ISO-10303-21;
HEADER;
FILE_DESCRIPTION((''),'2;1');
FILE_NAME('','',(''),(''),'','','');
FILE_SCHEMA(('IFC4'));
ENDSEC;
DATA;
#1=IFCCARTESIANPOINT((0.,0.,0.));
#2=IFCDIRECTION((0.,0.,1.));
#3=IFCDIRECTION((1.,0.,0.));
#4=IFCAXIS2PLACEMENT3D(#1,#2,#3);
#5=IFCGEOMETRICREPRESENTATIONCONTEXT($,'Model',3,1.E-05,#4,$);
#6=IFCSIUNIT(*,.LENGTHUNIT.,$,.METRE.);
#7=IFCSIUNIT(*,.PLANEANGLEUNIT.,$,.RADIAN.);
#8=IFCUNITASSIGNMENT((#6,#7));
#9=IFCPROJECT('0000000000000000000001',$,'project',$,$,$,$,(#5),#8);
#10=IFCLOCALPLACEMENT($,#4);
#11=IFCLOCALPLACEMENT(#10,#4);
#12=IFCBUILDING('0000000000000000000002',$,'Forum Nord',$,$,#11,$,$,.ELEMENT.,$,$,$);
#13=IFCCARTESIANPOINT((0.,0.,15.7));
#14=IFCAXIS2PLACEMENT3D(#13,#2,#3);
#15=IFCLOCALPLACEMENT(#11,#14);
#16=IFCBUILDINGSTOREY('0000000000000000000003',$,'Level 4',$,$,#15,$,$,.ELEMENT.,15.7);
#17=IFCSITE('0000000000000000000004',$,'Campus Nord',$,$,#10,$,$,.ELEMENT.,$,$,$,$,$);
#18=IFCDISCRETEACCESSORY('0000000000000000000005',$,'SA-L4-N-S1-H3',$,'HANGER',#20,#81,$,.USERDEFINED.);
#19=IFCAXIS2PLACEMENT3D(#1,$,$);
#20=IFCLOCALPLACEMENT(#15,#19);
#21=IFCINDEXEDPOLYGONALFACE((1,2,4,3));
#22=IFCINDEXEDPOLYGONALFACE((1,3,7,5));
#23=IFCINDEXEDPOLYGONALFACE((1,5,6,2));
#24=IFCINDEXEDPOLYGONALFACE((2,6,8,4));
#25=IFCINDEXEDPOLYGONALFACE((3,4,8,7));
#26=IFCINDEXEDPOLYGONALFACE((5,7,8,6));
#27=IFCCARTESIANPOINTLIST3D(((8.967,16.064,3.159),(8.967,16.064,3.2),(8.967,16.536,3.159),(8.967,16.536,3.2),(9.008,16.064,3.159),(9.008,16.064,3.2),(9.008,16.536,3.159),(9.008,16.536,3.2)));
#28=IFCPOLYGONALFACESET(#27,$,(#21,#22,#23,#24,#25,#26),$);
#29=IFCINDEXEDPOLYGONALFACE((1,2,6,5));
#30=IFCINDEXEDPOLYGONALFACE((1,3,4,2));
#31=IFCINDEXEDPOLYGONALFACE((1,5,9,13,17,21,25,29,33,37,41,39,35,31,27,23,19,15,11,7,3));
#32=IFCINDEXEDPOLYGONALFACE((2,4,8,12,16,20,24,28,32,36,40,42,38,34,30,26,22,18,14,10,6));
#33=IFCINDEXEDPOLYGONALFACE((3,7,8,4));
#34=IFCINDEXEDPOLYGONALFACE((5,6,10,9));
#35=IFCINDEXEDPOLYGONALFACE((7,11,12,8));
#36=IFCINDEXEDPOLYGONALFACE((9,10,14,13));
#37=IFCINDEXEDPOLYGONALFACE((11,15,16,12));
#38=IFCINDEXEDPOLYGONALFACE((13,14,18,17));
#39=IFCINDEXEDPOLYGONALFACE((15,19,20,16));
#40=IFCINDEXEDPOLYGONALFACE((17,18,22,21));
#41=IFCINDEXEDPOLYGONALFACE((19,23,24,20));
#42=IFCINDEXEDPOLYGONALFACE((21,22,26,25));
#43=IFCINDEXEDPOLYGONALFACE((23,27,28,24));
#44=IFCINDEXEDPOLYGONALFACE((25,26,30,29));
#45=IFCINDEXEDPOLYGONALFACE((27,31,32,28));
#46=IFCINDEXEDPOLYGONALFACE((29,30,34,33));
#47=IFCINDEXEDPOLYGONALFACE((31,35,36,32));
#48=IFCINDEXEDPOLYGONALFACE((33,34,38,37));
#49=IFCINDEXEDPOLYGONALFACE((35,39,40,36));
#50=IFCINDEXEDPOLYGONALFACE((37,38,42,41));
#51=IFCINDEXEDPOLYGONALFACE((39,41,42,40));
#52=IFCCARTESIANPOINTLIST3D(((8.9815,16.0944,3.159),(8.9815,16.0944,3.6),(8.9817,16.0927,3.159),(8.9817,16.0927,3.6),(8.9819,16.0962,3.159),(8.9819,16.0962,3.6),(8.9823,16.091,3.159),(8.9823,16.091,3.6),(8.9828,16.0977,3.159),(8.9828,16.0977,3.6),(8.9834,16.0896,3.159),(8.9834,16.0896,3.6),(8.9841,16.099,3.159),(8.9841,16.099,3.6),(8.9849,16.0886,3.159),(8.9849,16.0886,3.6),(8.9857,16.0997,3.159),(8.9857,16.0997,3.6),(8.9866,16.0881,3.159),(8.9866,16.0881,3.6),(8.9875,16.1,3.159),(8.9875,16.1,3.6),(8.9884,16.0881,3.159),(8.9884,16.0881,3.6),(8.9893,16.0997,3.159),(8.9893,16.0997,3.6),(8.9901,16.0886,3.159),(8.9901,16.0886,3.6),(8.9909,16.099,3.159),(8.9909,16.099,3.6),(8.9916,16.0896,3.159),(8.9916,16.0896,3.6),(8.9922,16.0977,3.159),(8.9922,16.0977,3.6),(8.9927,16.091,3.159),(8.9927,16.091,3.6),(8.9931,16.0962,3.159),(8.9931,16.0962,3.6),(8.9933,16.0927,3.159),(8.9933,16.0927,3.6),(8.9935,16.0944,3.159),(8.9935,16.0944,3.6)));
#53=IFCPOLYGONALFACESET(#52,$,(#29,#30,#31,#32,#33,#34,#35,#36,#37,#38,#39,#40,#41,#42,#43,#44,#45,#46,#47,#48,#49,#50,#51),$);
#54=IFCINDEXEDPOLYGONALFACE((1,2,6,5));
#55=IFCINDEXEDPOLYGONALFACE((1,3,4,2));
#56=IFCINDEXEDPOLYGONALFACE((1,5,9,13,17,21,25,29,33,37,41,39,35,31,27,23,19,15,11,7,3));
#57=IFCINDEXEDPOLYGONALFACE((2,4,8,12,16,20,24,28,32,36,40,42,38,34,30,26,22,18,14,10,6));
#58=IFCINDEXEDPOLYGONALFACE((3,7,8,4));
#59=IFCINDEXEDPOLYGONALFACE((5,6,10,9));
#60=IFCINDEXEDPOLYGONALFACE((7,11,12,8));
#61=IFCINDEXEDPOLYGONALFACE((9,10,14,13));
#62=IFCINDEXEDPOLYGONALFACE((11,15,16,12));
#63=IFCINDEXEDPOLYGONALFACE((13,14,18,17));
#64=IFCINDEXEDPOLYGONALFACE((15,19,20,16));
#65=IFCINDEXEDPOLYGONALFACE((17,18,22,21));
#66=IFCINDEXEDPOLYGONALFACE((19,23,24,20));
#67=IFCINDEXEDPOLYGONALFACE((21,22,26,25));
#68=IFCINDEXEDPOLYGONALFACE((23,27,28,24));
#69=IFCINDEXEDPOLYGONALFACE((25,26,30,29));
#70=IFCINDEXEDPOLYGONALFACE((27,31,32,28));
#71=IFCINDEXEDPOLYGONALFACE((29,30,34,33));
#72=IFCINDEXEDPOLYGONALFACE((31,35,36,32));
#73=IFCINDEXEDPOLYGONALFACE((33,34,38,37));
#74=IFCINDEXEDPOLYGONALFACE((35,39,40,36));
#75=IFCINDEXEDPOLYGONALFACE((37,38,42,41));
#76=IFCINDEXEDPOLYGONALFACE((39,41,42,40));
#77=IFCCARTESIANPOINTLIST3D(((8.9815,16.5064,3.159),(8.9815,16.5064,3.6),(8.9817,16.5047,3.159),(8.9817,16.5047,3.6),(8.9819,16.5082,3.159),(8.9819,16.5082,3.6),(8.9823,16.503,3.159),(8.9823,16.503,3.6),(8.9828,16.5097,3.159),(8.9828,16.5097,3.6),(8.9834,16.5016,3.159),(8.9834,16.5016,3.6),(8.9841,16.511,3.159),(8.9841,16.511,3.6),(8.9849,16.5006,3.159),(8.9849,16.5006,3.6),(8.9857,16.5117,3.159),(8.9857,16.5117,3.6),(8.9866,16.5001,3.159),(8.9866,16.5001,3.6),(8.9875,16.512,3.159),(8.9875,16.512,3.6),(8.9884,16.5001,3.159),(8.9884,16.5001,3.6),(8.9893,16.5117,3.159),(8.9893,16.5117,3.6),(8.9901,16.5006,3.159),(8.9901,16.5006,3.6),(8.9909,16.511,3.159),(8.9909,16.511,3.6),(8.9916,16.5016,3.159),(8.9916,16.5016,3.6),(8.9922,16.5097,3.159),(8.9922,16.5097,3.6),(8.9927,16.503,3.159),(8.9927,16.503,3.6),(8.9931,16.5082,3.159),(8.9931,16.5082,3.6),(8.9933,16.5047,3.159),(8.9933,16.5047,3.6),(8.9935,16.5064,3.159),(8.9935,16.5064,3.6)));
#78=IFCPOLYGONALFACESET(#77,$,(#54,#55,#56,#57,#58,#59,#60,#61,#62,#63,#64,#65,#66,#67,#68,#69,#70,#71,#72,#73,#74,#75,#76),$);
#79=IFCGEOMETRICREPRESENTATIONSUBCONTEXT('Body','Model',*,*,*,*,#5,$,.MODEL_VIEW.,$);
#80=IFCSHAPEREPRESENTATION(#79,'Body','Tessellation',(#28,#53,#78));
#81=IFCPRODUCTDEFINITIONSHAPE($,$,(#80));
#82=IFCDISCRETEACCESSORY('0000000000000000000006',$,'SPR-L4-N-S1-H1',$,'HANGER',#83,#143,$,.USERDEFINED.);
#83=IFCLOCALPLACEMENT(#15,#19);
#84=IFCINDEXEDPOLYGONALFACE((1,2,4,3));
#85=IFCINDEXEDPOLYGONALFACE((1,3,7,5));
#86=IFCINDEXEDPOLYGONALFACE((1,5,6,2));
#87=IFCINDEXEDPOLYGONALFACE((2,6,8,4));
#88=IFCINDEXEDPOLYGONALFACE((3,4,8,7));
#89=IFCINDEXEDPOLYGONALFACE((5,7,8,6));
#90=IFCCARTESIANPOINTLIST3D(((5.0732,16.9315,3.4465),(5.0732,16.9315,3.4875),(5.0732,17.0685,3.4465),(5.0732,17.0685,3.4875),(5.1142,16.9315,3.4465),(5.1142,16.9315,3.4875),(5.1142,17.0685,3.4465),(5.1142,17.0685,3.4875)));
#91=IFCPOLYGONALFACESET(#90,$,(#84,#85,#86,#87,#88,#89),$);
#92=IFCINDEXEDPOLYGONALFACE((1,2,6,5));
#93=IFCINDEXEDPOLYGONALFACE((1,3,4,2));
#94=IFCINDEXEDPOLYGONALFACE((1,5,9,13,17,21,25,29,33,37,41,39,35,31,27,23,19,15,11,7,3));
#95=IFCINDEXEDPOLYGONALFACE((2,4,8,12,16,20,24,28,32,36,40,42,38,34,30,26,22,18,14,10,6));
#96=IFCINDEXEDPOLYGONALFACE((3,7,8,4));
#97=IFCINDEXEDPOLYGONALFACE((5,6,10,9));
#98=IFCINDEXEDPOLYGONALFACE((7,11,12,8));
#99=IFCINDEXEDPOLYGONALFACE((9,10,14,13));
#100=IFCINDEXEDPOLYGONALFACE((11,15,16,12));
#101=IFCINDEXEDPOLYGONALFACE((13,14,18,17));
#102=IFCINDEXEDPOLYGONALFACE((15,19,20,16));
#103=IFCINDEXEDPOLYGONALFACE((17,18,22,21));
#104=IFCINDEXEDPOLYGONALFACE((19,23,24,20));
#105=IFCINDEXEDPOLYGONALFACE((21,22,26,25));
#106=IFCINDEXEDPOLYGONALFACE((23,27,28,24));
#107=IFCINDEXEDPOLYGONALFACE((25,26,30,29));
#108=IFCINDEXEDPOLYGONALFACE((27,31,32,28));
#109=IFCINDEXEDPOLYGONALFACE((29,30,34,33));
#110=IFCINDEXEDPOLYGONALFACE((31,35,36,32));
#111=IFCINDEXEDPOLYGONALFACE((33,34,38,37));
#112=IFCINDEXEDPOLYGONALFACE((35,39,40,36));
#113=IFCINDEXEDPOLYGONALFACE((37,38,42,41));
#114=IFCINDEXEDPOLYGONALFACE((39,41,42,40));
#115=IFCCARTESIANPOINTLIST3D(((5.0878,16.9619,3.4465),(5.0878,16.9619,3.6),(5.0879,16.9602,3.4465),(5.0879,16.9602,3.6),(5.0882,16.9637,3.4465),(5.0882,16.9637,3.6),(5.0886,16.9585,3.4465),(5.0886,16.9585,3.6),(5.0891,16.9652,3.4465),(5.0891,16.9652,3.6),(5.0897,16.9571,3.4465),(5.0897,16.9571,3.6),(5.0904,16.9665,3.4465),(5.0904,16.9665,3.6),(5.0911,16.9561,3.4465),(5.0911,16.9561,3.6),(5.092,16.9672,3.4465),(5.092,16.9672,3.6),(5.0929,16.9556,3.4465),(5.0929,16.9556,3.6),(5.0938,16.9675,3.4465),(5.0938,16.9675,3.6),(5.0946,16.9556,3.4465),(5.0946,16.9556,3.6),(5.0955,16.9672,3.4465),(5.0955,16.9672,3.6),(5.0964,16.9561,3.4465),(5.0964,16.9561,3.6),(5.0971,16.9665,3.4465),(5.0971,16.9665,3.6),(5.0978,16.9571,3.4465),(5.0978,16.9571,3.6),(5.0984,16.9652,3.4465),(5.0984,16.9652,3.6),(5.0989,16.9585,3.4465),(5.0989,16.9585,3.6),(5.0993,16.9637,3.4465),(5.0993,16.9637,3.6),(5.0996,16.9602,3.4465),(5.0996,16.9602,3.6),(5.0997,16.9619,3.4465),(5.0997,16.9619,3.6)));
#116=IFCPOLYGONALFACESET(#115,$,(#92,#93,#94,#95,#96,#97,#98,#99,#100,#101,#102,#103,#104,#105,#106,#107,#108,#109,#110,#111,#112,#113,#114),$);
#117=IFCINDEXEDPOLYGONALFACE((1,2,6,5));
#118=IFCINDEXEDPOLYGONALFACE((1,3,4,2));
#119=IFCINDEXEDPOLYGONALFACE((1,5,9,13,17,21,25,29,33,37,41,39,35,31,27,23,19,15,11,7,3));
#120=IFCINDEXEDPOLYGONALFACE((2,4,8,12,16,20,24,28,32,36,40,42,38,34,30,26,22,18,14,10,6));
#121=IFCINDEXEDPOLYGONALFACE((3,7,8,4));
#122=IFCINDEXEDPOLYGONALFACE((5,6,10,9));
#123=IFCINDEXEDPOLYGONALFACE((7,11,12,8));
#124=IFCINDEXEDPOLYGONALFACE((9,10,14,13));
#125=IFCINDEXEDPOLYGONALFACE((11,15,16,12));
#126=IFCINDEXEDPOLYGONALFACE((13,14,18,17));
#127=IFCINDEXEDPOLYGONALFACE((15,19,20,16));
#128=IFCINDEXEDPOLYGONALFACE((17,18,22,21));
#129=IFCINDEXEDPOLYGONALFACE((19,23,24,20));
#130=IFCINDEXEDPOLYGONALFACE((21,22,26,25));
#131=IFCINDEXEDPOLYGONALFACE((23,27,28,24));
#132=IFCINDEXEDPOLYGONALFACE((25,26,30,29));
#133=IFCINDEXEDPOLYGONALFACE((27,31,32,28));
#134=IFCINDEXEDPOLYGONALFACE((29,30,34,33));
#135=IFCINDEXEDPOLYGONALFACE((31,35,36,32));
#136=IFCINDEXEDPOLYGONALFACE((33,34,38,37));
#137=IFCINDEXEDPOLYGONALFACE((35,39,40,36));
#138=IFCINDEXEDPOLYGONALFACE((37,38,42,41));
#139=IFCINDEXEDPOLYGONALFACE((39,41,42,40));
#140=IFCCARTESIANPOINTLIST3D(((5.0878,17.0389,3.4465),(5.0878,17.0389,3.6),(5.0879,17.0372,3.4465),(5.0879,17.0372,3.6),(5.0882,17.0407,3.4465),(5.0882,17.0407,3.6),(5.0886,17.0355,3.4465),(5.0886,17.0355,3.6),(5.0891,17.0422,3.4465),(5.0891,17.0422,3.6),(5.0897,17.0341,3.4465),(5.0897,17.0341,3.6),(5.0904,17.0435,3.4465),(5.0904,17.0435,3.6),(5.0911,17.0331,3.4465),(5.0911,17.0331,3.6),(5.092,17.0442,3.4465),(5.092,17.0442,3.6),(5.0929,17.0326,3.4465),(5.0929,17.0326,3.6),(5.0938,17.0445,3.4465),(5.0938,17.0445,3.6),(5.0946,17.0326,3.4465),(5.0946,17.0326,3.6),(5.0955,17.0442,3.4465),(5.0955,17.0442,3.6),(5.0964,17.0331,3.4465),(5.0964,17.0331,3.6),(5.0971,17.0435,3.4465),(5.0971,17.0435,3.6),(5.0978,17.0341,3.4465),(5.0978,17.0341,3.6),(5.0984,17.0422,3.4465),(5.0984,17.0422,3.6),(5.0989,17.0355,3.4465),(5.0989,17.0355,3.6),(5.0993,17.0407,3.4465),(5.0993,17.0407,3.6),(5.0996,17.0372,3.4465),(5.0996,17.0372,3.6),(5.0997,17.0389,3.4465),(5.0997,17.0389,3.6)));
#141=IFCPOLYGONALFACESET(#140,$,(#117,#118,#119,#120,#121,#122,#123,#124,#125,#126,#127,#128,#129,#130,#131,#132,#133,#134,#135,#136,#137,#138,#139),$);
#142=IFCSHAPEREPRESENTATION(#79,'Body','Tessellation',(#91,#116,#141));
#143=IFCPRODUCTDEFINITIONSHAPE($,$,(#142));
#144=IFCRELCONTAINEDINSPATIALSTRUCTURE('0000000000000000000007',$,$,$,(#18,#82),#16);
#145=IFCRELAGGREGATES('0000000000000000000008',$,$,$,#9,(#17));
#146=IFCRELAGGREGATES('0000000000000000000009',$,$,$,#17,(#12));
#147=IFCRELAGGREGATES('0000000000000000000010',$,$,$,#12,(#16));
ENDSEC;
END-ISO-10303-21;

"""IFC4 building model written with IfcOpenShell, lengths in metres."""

from ifc_helpers import new_model, si_unit, frame, frame_2d, origin_with_axes, origin_2d_with_axis, place, context, subcontext, project, spatial, rectangle, circle, extrude, element, save


model = new_model("IFC4")

# Units and contexts
model_context = context("Model", 3, precision=1e-05, world=origin_with_axes())
body_context = subcontext(model_context, "Body", "Model", "MODEL_VIEW")
ifc_project = project(units=[si_unit("LENGTHUNIT", "METRE"), si_unit("PLANEANGLEUNIT", "RADIAN")], contexts=[model_context])

# Site, building, storey
site_placement = place(None, origin_with_axes())
site = spatial("IfcSite", under=ifc_project, at=site_placement, Name="Campus Nord", CompositionType="ELEMENT")
building_placement = place(site_placement, origin_with_axes())
building = spatial("IfcBuilding", under=site, at=building_placement, Name="Forum Nord", CompositionType="ELEMENT")
storey_placement = place(building_placement, frame((0.0, 0.0, 15.7), z_axis=(0.0, 0.0, 1.0), x_axis=(1.0, 0.0, 0.0)))
storey = spatial("IfcBuildingStorey", under=building, at=storey_placement, Name="Level 4", CompositionType="ELEMENT", Elevation=15.7)

# Discrete accessories
for number, where, z_axis, x_axis, name in (
    (1, (8.9875, 16.3, 3.2), (0.0, 0.0, 1.0), (0.0, 1.0, 0.0), "SA-L4-N-S1-H3"),
):
    element("IfcDiscreteAccessory", number, at=place(storey_placement, frame(where, z_axis=z_axis, x_axis=x_axis)), inside=storey, Name=name, ObjectType="HANGER", PredefinedType="USERDEFINED", context=body_context, shape_type="SweptSolid", body=[
        extrude(rectangle(XDim=0.472, YDim=0.041, at=origin_2d_with_axis()), frame((0.0, 0.0, -0.041), z_axis=(0.0, 0.0, 1.0), x_axis=(1.0, 0.0, 0.0)), (0.0, 0.0, 1.0), 0.041),
        extrude(circle(Radius=0.006, at=frame_2d((-0.206, 0.0), x_axis=(1.0, 0.0))), frame((0.0, 0.0, -0.041), z_axis=(0.0, 0.0, 1.0), x_axis=(1.0, 0.0, 0.0)), (0.0, 0.0, 1.0), 0.441),
        extrude(circle(Radius=0.006, at=frame_2d((0.206, 0.0), x_axis=(1.0, 0.0))), frame((0.0, 0.0, -0.041), z_axis=(0.0, 0.0, 1.0), x_axis=(1.0, 0.0, 0.0)), (0.0, 0.0, 1.0), 0.441),
    ])
discrete_accessory_placement = place(storey_placement, frame((5.0938, 17.0, 3.4875), z_axis=(0.0, 0.0, 1.0), x_axis=(0.0, 1.0, 0.0)))
element("IfcDiscreteAccessory", 2, at=discrete_accessory_placement, inside=storey, Name="SPR-L4-N-S1-H1", ObjectType="HANGER", PredefinedType="USERDEFINED", context=body_context, shape_type="SweptSolid", body=[
    extrude(rectangle(XDim=0.137, YDim=0.041, at=origin_2d_with_axis()), frame((0.0, 0.0, -0.041), z_axis=(0.0, 0.0, 1.0), x_axis=(1.0, 0.0, 0.0)), (0.0, 0.0, 1.0), 0.041),
    extrude(circle(Radius=0.006, at=frame_2d((-0.0385, 0.0), x_axis=(1.0, 0.0))), frame((0.0, 0.0, -0.041), z_axis=(0.0, 0.0, 1.0), x_axis=(1.0, 0.0, 0.0)), (0.0, 0.0, 1.0), 0.1535),
    extrude(circle(Radius=0.006, at=frame_2d((0.0385, 0.0), x_axis=(1.0, 0.0))), frame((0.0, 0.0, -0.041), z_axis=(0.0, 0.0, 1.0), x_axis=(1.0, 0.0, 0.0)), (0.0, 0.0, 1.0), 0.1535),
])

save(model, "model.ifc")
